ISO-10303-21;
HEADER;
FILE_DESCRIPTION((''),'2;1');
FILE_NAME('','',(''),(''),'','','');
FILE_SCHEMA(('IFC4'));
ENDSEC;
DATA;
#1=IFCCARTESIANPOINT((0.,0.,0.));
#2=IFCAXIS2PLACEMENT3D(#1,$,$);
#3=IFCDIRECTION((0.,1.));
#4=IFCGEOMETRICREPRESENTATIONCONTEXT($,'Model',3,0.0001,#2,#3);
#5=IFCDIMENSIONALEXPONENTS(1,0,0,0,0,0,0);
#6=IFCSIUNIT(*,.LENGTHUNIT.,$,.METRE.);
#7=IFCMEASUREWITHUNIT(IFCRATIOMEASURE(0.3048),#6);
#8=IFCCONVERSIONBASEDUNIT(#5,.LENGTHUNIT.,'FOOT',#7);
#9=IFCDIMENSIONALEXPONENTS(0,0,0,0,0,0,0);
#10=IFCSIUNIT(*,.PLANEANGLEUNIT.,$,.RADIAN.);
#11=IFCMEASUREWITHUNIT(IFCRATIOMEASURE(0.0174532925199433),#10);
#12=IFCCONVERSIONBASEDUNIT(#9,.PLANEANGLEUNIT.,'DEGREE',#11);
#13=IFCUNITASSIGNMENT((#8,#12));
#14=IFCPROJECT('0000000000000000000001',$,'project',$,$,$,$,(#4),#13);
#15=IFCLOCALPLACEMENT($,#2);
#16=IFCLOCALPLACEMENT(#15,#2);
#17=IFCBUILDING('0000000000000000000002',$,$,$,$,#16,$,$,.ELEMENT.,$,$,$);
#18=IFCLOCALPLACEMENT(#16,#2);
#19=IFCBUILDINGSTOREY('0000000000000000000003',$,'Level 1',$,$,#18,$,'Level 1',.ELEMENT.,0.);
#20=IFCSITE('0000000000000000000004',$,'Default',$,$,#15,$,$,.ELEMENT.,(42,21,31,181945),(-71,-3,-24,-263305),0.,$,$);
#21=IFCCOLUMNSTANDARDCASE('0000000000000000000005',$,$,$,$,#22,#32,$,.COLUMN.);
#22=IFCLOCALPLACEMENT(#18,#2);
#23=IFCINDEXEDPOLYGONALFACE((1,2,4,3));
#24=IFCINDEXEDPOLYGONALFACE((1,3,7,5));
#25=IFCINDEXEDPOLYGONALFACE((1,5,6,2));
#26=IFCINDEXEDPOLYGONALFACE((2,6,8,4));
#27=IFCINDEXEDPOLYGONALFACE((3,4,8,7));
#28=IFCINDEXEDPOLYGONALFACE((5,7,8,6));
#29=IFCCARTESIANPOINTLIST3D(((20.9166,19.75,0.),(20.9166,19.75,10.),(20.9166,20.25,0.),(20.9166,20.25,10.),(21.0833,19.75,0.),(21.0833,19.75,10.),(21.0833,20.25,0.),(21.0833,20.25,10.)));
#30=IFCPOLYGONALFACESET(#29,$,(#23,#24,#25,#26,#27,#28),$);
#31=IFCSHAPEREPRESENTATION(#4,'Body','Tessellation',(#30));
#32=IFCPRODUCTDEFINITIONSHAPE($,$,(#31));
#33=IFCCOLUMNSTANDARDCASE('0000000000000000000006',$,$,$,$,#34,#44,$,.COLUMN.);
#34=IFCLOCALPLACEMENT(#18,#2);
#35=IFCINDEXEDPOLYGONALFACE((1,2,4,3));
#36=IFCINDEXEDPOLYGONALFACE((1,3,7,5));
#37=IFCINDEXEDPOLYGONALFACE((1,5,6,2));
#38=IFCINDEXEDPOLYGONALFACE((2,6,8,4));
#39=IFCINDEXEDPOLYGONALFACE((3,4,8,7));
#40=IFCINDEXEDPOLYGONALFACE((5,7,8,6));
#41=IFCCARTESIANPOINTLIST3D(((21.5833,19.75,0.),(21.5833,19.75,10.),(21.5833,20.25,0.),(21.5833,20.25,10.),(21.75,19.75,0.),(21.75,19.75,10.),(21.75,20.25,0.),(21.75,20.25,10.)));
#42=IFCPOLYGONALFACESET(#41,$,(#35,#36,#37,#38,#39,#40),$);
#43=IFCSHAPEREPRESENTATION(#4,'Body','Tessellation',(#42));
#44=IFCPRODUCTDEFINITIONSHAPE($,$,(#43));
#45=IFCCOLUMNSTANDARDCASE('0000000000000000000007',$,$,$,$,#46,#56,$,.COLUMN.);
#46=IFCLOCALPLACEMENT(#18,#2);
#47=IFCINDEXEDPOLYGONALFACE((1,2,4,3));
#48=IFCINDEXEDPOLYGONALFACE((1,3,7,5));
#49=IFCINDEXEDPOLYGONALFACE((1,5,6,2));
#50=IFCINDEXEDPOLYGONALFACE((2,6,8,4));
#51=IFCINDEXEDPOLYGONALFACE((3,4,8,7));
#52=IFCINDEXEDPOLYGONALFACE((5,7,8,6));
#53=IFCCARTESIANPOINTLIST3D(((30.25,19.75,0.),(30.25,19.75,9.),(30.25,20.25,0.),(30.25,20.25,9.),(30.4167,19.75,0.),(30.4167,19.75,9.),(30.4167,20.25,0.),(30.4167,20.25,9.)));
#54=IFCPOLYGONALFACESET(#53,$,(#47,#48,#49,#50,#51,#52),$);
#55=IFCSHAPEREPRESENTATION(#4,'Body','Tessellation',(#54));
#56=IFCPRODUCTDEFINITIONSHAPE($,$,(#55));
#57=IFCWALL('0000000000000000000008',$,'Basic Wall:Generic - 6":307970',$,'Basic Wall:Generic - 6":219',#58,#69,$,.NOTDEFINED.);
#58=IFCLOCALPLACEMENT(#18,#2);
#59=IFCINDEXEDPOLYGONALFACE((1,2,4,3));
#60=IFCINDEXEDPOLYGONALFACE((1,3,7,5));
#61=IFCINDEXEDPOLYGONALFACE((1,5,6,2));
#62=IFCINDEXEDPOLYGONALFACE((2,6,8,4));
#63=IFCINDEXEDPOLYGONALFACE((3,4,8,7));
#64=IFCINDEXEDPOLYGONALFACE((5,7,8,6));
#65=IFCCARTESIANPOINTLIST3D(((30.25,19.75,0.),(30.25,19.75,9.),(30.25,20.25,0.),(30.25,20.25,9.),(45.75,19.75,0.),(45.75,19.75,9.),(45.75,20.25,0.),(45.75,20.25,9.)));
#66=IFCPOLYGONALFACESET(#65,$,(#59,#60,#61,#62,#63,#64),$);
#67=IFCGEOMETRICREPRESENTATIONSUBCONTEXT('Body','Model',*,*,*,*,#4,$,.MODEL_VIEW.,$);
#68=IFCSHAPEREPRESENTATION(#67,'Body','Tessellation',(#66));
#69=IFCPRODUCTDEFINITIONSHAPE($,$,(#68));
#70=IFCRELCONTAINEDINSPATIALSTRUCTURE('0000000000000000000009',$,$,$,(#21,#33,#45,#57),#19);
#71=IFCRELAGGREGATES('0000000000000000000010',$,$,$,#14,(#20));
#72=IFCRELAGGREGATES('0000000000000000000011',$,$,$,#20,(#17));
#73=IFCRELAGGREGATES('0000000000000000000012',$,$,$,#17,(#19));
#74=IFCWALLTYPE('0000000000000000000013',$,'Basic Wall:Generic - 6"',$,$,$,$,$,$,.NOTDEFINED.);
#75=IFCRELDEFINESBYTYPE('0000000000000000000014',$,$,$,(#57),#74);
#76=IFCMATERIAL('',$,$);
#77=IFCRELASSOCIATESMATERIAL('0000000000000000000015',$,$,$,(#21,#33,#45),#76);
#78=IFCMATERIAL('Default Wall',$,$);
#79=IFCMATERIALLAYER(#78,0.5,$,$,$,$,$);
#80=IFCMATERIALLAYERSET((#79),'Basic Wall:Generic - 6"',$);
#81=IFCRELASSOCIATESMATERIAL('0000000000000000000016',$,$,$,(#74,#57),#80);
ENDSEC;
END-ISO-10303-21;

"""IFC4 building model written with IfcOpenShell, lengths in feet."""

from ifc_helpers import new_model, entity, si_unit, converted_unit, direction, frame, frame_2d, origin, place, context, subcontext, project, spatial, rectangle, extrude, material, layer, layer_set, layer_usage, type_object, element, save


model = new_model("IFC4")

# Units and contexts
model_context = context("Model", 3, precision=0.0001, world=origin(), true_north=direction((0.0, 1.0)))
body_context = subcontext(model_context, "Body", "Model", "MODEL_VIEW")
ifc_project = project(units=[converted_unit("LENGTHUNIT", "FOOT", entity("IfcRatioMeasure", 0.3048), si_unit("LENGTHUNIT", "METRE"), dimensions=[1, 0, 0, 0, 0, 0, 0]), converted_unit("PLANEANGLEUNIT", "DEGREE", entity("IfcRatioMeasure", 0.0174532925199433), si_unit("PLANEANGLEUNIT", "RADIAN"), dimensions=[0, 0, 0, 0, 0, 0, 0])], contexts=[model_context])

# Site, building, storey
site_placement = place(None, origin())
site = spatial("IfcSite", under=ifc_project, at=site_placement, Name="Default", CompositionType="ELEMENT", RefLatitude=(42, 21, 31, 181945), RefLongitude=(-71, -3, -24, -263305), RefElevation=0.0)
building_placement = place(site_placement, origin())
building = spatial("IfcBuilding", under=site, at=building_placement, CompositionType="ELEMENT")
storey_placement = place(building_placement, origin())
storey = spatial("IfcBuildingStorey", under=building, at=storey_placement, Name="Level 1", LongName="Level 1", CompositionType="ELEMENT", Elevation=0.0)

# Columns
ifc_material_1 = material(Name="")
placement_1 = place(storey_placement, frame((0.25, 20.0, 0.0)))
for number, where, z_axis, x_axis in (
    (1, (20.75, 0.0, 0.0), (0.0, 0.0, 1.0), (1.0, 0.0, 0.0)),
    (2, (21.4167, 0.0, 0.0), (0.0, 0.0, 1.0), (1.0, 0.0, 0.0)),
):
    element("IfcColumnStandardCase", number, at=place(placement_1, frame(where, z_axis=z_axis, x_axis=x_axis)), inside=storey, material=ifc_material_1, PredefinedType="COLUMN", context=model_context, shape_type="SweptSolid", body=[
        extrude(rectangle(XDim=0.1667, YDim=0.5), origin(), (0.0, 0.0, 1.0), 10.0),
    ])
wall_placement = place(storey_placement, frame((30.25, 20.0, 0.0)))
for number, where, z_axis, x_axis in (
    (3, (0.0833, 0.0, 0.0), (0.0, 0.0, 1.0), (1.0, 0.0, 0.0)),
):
    element("IfcColumnStandardCase", number, at=place(wall_placement, frame(where, z_axis=z_axis, x_axis=x_axis)), inside=storey, material=ifc_material_1, PredefinedType="COLUMN", context=model_context, shape_type="SweptSolid", body=[
        extrude(rectangle(XDim=0.1667, YDim=0.5), origin(), (0.0, 0.0, 1.0), 9.0),
    ])

# Wall
ifc_material_2 = material(Name="Default Wall")
ifc_layer = layer(ifc_material_2, 0.5)
ifc_layer_set = layer_set([ifc_layer], Name="Basic Wall:Generic - 6\"")
ifc_layer_usage = layer_usage(ifc_layer_set, "AXIS2", "NEGATIVE", 0.25)
wall_type = type_object("IfcWallType", Name="Basic Wall:Generic - 6\"", PredefinedType="NOTDEFINED", material=ifc_layer_set)
element("IfcWall", 4, at=wall_placement, inside=storey, type_object=wall_type, material=ifc_layer_usage, Name="Basic Wall:Generic - 6\":307970", ObjectType="Basic Wall:Generic - 6\":219", PredefinedType="NOTDEFINED", context=body_context, shape_type="SweptSolid", body=[
    extrude(rectangle(XDim=15.5, YDim=0.5, at=frame_2d((7.75, 0.0), x_axis=(-1.0, 0.0))), origin(), (0.0, 0.0, 1.0), 9.0),
])

save(model, "model.ifc")
